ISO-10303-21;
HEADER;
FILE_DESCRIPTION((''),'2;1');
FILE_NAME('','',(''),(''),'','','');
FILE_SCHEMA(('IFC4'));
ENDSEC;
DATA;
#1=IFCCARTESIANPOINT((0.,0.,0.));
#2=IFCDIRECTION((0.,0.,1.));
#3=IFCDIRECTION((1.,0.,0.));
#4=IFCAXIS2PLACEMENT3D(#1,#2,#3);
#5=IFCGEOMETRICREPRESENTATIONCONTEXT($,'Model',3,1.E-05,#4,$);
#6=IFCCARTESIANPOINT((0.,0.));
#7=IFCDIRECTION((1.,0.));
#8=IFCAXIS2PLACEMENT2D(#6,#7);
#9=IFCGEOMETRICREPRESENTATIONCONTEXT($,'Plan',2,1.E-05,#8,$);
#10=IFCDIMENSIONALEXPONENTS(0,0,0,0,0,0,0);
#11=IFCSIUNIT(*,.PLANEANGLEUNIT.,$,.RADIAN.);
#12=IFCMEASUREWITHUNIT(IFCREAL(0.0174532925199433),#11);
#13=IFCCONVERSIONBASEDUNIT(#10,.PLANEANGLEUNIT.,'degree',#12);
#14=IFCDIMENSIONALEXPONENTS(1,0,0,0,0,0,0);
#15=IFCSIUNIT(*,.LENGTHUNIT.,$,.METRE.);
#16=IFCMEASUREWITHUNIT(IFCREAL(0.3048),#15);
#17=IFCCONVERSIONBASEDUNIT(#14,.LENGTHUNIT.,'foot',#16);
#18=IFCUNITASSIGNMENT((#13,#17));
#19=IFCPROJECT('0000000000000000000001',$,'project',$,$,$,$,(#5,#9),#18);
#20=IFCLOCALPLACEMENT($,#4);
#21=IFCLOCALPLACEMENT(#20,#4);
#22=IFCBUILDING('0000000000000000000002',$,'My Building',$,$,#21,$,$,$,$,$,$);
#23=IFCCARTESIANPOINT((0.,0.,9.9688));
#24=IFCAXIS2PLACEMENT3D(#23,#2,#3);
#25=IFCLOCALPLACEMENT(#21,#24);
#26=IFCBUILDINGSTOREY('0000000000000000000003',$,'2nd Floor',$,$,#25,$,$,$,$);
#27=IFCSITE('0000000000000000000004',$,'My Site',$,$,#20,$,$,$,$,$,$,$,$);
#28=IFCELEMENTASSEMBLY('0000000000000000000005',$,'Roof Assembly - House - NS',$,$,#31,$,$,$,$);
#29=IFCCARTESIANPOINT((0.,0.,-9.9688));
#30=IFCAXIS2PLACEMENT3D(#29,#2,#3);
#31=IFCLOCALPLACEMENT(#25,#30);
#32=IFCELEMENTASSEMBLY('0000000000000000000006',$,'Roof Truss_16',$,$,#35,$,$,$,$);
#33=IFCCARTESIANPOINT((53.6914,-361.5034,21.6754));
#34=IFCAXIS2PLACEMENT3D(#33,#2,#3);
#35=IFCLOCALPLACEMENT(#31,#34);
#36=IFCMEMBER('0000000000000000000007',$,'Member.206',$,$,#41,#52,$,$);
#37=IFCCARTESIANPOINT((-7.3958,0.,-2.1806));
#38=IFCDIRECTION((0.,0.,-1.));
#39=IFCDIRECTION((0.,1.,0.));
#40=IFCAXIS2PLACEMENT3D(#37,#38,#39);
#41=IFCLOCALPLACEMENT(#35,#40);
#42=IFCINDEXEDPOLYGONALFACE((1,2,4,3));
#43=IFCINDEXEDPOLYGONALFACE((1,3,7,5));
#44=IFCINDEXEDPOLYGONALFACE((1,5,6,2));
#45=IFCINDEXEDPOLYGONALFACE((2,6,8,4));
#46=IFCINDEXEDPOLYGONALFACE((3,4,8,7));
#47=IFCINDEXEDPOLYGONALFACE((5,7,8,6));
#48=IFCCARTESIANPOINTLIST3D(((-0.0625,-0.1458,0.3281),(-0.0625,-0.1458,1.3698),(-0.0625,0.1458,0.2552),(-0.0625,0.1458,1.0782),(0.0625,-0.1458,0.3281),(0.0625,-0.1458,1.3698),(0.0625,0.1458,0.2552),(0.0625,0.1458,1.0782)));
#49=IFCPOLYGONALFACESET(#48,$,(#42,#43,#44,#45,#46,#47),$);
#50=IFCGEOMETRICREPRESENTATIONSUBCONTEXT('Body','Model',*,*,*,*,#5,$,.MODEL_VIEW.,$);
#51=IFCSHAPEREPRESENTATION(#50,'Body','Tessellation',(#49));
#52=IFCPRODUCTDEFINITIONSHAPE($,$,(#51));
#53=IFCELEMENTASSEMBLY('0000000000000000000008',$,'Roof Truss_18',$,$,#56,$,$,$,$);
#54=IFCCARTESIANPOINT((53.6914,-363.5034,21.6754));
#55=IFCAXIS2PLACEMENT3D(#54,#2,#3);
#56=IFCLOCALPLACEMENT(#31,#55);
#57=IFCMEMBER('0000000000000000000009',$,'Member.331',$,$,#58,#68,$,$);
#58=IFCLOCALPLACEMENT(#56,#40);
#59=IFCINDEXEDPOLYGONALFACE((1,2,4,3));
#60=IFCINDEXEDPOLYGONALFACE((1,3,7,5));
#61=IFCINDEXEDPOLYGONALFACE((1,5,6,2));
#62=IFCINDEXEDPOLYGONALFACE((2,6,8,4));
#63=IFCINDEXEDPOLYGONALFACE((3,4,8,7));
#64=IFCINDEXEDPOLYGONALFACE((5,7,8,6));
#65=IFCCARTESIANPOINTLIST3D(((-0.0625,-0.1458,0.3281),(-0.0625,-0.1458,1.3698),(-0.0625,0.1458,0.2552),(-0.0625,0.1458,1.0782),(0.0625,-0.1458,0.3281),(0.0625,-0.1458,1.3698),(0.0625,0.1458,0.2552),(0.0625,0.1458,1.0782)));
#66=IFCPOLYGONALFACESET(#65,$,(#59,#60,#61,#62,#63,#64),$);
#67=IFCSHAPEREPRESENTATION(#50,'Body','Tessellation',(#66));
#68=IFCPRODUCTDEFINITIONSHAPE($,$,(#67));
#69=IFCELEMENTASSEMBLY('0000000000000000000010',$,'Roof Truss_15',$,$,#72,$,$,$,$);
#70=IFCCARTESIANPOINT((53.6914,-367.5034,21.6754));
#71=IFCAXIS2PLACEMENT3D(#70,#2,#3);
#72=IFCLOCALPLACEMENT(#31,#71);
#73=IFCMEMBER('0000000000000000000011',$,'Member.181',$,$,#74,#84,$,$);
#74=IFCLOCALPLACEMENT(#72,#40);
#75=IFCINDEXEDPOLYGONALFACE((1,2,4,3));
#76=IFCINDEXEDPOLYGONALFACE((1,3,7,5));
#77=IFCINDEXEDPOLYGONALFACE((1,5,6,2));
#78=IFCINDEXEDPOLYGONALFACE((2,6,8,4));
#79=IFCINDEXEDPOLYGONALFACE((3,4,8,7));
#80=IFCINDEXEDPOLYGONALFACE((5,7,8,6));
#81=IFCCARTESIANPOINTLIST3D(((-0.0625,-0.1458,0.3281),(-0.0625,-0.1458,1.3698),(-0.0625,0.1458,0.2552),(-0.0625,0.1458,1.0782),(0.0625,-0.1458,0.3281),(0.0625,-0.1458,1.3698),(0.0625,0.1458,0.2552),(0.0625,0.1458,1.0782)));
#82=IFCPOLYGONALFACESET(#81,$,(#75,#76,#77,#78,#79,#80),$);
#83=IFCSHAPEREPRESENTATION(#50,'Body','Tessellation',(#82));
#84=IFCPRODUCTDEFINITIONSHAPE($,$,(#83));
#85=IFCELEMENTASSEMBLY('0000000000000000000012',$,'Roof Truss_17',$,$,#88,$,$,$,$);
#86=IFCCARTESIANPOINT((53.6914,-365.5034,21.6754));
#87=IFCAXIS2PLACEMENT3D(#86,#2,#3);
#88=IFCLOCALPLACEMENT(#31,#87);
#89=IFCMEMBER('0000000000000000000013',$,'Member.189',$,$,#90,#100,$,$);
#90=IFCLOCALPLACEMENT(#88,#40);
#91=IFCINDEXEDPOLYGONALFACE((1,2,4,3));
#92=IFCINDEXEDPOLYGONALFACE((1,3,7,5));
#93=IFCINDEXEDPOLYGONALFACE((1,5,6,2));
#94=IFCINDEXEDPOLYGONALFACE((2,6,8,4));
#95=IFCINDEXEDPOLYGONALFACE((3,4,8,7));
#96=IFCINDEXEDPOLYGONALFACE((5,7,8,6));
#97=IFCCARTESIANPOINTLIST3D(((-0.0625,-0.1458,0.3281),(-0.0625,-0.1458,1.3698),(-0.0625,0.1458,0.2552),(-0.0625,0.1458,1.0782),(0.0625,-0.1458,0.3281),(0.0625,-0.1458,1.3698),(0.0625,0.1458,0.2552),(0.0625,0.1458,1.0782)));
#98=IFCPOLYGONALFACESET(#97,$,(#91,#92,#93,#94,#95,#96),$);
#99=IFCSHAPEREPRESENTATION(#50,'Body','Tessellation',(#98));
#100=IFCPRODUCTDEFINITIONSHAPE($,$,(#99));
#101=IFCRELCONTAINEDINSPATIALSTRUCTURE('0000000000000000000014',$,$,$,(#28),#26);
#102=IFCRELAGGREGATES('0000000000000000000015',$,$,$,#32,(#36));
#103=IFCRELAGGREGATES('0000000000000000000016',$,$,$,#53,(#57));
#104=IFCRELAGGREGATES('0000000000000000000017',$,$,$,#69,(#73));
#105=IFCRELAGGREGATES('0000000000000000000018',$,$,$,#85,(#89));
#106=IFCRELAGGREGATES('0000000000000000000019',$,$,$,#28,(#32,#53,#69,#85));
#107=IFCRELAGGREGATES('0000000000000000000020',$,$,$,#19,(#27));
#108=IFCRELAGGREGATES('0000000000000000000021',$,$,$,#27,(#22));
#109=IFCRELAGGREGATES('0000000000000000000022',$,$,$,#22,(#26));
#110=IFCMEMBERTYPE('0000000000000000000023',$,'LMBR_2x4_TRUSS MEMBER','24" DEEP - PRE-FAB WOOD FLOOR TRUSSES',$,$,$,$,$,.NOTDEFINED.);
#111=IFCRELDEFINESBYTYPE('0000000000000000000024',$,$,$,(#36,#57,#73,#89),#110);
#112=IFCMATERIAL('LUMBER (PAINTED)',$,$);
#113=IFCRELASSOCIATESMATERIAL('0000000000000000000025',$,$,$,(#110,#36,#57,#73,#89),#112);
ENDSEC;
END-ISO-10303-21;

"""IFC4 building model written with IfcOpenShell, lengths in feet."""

from ifc_helpers import new_model, entity, si_unit, converted_unit, frame, origin_with_axes, origin_2d_with_axis, place, context, subcontext, project, spatial, indexed_curve, outline, extrude, clip, halfspace, material, material_profile, profile_set, profile_usage, type_object, element, aggregate, save


model = new_model("IFC4")

# Units and contexts
model_context = context("Model", 3, precision=1e-05, world=origin_with_axes())
plan_context = context("Plan", 2, precision=1e-05, world=origin_2d_with_axis())
body_context = subcontext(model_context, "Body", "Model", "MODEL_VIEW")
ifc_project = project(units=[converted_unit("PLANEANGLEUNIT", "degree", entity("IfcReal", 0.0174532925199433), si_unit("PLANEANGLEUNIT", "RADIAN"), dimensions=[0, 0, 0, 0, 0, 0, 0]), converted_unit("LENGTHUNIT", "foot", entity("IfcReal", 0.3048), si_unit("LENGTHUNIT", "METRE"), dimensions=[1, 0, 0, 0, 0, 0, 0])], contexts=[model_context, plan_context])

# Site, building, storey
site_placement = place(None, origin_with_axes())
site = spatial("IfcSite", under=ifc_project, at=site_placement, Name="My Site")
building_placement = place(site_placement, origin_with_axes())
building = spatial("IfcBuilding", under=site, at=building_placement, Name="My Building")
storey_placement = place(building_placement, frame((0.0, 0.0, 9.9688), z_axis=(0.0, 0.0, 1.0), x_axis=(1.0, 0.0, 0.0)))
storey = spatial("IfcBuildingStorey", under=building, at=storey_placement, Name="2nd Floor")

# Element assemblies, members
assembly_1_placement = place(storey_placement, frame((0.0, 0.0, -9.9688), z_axis=(0.0, 0.0, 1.0), x_axis=(1.0, 0.0, 0.0)))
assembly_1 = element("IfcElementAssembly", 1, at=assembly_1_placement, inside=storey, Name="Roof Assembly - House - NS")
assembly_2_placement = place(assembly_1_placement, frame((53.6914, -361.5034, 21.6754), z_axis=(0.0, 0.0, 1.0), x_axis=(1.0, 0.0, 0.0)))
assembly_2 = element("IfcElementAssembly", 2, at=assembly_2_placement, Name="Roof Truss_16")
ifc_material = material(Name="LUMBER (PAINTED)")
ifc_material_profile_1 = material_profile(ifc_material, outline(indexed_curve([(-0.0625, -0.1458), (0.0625, -0.1458), (0.0625, 0.1458), (-0.0625, 0.1458), (-0.0625, -0.1458)])))
ifc_profile_set_1 = profile_set([ifc_material_profile_1])
ifc_profile_usage_1 = profile_usage(ifc_profile_set_1)
member_type_1 = type_object("IfcMemberType", Name="LMBR_2x4_TRUSS MEMBER", Description="24\" DEEP - PRE-FAB WOOD FLOOR TRUSSES", PredefinedType="NOTDEFINED", material=ifc_profile_set_1)
member_1_placement = place(assembly_2_placement, frame((-7.3958, 0.0, -2.1806), z_axis=(0.0, 0.0, -1.0), x_axis=(0.0, 1.0, 0.0)))
member_1 = element("IfcMember", 3, at=member_1_placement, type_object=member_type_1, material=ifc_profile_usage_1, Name="Member.206", context=body_context, shape_type="Clipping", body=[
    clip(clip(extrude(outline(indexed_curve([(-0.0625, -0.1458), (0.0625, -0.1458), (0.0625, 0.1458), (-0.0625, 0.1458), (-0.0625, -0.1458)])), origin_with_axes(), (0.0, 0.0, 1.0), 1.3698), halfspace(frame((0.0, 7.5424, -1.5944), z_axis=(0.0, -0.242599, -0.970127), x_axis=(-1.0, 0.000001, 0.0)), False)), halfspace(frame((397.5032, -0.1458, 1.3698), z_axis=(0.0, 0.707107, 0.707107), x_axis=(1.0, 0.0, 0.0)), False)),
])
assembly_3_placement = place(assembly_1_placement, frame((53.6914, -363.5034, 21.6754), z_axis=(0.0, 0.0, 1.0), x_axis=(1.0, 0.0, 0.0)))
assembly_3 = element("IfcElementAssembly", 4, at=assembly_3_placement, Name="Roof Truss_18")
ifc_profile_usage_2 = profile_usage(ifc_profile_set_1)
member_2_placement = place(assembly_3_placement, frame((-7.3958, 0.0, -2.1806), z_axis=(0.0, 0.0, -1.0), x_axis=(0.0, 1.0, 0.0)))
member_2 = element("IfcMember", 5, at=member_2_placement, type_object=member_type_1, material=ifc_profile_usage_2, Name="Member.331", context=body_context, shape_type="Clipping", body=[
    clip(clip(extrude(outline(indexed_curve([(-0.0625, -0.1458), (0.0625, -0.1458), (0.0625, 0.1458), (-0.0625, 0.1458), (-0.0625, -0.1458)])), origin_with_axes(), (0.0, 0.0, 1.0), 1.3698), halfspace(frame((0.0, 7.5424, -1.5944), z_axis=(0.0, -0.242599, -0.970127), x_axis=(-1.0, 0.000001, 0.0)), False)), halfspace(frame((397.5032, -0.1458, 1.3698), z_axis=(0.0, 0.707107, 0.707107), x_axis=(1.0, 0.0, 0.0)), False)),
])
assembly_4_placement = place(assembly_1_placement, frame((53.6914, -367.5034, 21.6754), z_axis=(0.0, 0.0, 1.0), x_axis=(1.0, 0.0, 0.0)))
assembly_4 = element("IfcElementAssembly", 6, at=assembly_4_placement, Name="Roof Truss_15")
ifc_profile_usage_3 = profile_usage(ifc_profile_set_1)
member_3_placement = place(assembly_4_placement, frame((-7.3958, 0.0, -2.1806), z_axis=(0.0, 0.0, -1.0), x_axis=(0.0, 1.0, 0.0)))
member_3 = element("IfcMember", 7, at=member_3_placement, type_object=member_type_1, material=ifc_profile_usage_3, Name="Member.181", context=body_context, shape_type="Clipping", body=[
    clip(clip(extrude(outline(indexed_curve([(-0.0625, -0.1458), (0.0625, -0.1458), (0.0625, 0.1458), (-0.0625, 0.1458), (-0.0625, -0.1458)])), origin_with_axes(), (0.0, 0.0, 1.0), 1.3698), halfspace(frame((0.0, 7.5424, -1.5944), z_axis=(0.0, -0.242599, -0.970127), x_axis=(-1.0, 0.000001, 0.0)), False)), halfspace(frame((397.5032, -0.1458, 1.3698), z_axis=(0.0, 0.707107, 0.707107), x_axis=(1.0, 0.0, 0.0)), False)),
])
assembly_5_placement = place(assembly_1_placement, frame((53.6914, -365.5034, 21.6754), z_axis=(0.0, 0.0, 1.0), x_axis=(1.0, 0.0, 0.0)))
assembly_5 = element("IfcElementAssembly", 8, at=assembly_5_placement, Name="Roof Truss_17")
ifc_profile_usage_4 = profile_usage(ifc_profile_set_1)
member_4_placement = place(assembly_5_placement, frame((-7.3958, 0.0, -2.1806), z_axis=(0.0, 0.0, -1.0), x_axis=(0.0, 1.0, 0.0)))
member_4 = element("IfcMember", 9, at=member_4_placement, type_object=member_type_1, material=ifc_profile_usage_4, Name="Member.189", context=body_context, shape_type="Clipping", body=[
    clip(clip(extrude(outline(indexed_curve([(-0.0625, -0.1458), (0.0625, -0.1458), (0.0625, 0.1458), (-0.0625, 0.1458), (-0.0625, -0.1458)])), origin_with_axes(), (0.0, 0.0, 1.0), 1.3698), halfspace(frame((0.0, 7.5424, -1.5944), z_axis=(0.0, -0.242599, -0.970127), x_axis=(-1.0, 0.000001, 0.0)), False)), halfspace(frame((397.5032, -0.1458, 1.3698), z_axis=(0.0, 0.707107, 0.707107), x_axis=(1.0, 0.0, 0.0)), False)),
])
aggregate(assembly_2, [member_1])
aggregate(assembly_3, [member_2])
aggregate(assembly_4, [member_3])
aggregate(assembly_5, [member_4])
aggregate(assembly_1, [assembly_2, assembly_3, assembly_4, assembly_5])

save(model, "model.ifc")
